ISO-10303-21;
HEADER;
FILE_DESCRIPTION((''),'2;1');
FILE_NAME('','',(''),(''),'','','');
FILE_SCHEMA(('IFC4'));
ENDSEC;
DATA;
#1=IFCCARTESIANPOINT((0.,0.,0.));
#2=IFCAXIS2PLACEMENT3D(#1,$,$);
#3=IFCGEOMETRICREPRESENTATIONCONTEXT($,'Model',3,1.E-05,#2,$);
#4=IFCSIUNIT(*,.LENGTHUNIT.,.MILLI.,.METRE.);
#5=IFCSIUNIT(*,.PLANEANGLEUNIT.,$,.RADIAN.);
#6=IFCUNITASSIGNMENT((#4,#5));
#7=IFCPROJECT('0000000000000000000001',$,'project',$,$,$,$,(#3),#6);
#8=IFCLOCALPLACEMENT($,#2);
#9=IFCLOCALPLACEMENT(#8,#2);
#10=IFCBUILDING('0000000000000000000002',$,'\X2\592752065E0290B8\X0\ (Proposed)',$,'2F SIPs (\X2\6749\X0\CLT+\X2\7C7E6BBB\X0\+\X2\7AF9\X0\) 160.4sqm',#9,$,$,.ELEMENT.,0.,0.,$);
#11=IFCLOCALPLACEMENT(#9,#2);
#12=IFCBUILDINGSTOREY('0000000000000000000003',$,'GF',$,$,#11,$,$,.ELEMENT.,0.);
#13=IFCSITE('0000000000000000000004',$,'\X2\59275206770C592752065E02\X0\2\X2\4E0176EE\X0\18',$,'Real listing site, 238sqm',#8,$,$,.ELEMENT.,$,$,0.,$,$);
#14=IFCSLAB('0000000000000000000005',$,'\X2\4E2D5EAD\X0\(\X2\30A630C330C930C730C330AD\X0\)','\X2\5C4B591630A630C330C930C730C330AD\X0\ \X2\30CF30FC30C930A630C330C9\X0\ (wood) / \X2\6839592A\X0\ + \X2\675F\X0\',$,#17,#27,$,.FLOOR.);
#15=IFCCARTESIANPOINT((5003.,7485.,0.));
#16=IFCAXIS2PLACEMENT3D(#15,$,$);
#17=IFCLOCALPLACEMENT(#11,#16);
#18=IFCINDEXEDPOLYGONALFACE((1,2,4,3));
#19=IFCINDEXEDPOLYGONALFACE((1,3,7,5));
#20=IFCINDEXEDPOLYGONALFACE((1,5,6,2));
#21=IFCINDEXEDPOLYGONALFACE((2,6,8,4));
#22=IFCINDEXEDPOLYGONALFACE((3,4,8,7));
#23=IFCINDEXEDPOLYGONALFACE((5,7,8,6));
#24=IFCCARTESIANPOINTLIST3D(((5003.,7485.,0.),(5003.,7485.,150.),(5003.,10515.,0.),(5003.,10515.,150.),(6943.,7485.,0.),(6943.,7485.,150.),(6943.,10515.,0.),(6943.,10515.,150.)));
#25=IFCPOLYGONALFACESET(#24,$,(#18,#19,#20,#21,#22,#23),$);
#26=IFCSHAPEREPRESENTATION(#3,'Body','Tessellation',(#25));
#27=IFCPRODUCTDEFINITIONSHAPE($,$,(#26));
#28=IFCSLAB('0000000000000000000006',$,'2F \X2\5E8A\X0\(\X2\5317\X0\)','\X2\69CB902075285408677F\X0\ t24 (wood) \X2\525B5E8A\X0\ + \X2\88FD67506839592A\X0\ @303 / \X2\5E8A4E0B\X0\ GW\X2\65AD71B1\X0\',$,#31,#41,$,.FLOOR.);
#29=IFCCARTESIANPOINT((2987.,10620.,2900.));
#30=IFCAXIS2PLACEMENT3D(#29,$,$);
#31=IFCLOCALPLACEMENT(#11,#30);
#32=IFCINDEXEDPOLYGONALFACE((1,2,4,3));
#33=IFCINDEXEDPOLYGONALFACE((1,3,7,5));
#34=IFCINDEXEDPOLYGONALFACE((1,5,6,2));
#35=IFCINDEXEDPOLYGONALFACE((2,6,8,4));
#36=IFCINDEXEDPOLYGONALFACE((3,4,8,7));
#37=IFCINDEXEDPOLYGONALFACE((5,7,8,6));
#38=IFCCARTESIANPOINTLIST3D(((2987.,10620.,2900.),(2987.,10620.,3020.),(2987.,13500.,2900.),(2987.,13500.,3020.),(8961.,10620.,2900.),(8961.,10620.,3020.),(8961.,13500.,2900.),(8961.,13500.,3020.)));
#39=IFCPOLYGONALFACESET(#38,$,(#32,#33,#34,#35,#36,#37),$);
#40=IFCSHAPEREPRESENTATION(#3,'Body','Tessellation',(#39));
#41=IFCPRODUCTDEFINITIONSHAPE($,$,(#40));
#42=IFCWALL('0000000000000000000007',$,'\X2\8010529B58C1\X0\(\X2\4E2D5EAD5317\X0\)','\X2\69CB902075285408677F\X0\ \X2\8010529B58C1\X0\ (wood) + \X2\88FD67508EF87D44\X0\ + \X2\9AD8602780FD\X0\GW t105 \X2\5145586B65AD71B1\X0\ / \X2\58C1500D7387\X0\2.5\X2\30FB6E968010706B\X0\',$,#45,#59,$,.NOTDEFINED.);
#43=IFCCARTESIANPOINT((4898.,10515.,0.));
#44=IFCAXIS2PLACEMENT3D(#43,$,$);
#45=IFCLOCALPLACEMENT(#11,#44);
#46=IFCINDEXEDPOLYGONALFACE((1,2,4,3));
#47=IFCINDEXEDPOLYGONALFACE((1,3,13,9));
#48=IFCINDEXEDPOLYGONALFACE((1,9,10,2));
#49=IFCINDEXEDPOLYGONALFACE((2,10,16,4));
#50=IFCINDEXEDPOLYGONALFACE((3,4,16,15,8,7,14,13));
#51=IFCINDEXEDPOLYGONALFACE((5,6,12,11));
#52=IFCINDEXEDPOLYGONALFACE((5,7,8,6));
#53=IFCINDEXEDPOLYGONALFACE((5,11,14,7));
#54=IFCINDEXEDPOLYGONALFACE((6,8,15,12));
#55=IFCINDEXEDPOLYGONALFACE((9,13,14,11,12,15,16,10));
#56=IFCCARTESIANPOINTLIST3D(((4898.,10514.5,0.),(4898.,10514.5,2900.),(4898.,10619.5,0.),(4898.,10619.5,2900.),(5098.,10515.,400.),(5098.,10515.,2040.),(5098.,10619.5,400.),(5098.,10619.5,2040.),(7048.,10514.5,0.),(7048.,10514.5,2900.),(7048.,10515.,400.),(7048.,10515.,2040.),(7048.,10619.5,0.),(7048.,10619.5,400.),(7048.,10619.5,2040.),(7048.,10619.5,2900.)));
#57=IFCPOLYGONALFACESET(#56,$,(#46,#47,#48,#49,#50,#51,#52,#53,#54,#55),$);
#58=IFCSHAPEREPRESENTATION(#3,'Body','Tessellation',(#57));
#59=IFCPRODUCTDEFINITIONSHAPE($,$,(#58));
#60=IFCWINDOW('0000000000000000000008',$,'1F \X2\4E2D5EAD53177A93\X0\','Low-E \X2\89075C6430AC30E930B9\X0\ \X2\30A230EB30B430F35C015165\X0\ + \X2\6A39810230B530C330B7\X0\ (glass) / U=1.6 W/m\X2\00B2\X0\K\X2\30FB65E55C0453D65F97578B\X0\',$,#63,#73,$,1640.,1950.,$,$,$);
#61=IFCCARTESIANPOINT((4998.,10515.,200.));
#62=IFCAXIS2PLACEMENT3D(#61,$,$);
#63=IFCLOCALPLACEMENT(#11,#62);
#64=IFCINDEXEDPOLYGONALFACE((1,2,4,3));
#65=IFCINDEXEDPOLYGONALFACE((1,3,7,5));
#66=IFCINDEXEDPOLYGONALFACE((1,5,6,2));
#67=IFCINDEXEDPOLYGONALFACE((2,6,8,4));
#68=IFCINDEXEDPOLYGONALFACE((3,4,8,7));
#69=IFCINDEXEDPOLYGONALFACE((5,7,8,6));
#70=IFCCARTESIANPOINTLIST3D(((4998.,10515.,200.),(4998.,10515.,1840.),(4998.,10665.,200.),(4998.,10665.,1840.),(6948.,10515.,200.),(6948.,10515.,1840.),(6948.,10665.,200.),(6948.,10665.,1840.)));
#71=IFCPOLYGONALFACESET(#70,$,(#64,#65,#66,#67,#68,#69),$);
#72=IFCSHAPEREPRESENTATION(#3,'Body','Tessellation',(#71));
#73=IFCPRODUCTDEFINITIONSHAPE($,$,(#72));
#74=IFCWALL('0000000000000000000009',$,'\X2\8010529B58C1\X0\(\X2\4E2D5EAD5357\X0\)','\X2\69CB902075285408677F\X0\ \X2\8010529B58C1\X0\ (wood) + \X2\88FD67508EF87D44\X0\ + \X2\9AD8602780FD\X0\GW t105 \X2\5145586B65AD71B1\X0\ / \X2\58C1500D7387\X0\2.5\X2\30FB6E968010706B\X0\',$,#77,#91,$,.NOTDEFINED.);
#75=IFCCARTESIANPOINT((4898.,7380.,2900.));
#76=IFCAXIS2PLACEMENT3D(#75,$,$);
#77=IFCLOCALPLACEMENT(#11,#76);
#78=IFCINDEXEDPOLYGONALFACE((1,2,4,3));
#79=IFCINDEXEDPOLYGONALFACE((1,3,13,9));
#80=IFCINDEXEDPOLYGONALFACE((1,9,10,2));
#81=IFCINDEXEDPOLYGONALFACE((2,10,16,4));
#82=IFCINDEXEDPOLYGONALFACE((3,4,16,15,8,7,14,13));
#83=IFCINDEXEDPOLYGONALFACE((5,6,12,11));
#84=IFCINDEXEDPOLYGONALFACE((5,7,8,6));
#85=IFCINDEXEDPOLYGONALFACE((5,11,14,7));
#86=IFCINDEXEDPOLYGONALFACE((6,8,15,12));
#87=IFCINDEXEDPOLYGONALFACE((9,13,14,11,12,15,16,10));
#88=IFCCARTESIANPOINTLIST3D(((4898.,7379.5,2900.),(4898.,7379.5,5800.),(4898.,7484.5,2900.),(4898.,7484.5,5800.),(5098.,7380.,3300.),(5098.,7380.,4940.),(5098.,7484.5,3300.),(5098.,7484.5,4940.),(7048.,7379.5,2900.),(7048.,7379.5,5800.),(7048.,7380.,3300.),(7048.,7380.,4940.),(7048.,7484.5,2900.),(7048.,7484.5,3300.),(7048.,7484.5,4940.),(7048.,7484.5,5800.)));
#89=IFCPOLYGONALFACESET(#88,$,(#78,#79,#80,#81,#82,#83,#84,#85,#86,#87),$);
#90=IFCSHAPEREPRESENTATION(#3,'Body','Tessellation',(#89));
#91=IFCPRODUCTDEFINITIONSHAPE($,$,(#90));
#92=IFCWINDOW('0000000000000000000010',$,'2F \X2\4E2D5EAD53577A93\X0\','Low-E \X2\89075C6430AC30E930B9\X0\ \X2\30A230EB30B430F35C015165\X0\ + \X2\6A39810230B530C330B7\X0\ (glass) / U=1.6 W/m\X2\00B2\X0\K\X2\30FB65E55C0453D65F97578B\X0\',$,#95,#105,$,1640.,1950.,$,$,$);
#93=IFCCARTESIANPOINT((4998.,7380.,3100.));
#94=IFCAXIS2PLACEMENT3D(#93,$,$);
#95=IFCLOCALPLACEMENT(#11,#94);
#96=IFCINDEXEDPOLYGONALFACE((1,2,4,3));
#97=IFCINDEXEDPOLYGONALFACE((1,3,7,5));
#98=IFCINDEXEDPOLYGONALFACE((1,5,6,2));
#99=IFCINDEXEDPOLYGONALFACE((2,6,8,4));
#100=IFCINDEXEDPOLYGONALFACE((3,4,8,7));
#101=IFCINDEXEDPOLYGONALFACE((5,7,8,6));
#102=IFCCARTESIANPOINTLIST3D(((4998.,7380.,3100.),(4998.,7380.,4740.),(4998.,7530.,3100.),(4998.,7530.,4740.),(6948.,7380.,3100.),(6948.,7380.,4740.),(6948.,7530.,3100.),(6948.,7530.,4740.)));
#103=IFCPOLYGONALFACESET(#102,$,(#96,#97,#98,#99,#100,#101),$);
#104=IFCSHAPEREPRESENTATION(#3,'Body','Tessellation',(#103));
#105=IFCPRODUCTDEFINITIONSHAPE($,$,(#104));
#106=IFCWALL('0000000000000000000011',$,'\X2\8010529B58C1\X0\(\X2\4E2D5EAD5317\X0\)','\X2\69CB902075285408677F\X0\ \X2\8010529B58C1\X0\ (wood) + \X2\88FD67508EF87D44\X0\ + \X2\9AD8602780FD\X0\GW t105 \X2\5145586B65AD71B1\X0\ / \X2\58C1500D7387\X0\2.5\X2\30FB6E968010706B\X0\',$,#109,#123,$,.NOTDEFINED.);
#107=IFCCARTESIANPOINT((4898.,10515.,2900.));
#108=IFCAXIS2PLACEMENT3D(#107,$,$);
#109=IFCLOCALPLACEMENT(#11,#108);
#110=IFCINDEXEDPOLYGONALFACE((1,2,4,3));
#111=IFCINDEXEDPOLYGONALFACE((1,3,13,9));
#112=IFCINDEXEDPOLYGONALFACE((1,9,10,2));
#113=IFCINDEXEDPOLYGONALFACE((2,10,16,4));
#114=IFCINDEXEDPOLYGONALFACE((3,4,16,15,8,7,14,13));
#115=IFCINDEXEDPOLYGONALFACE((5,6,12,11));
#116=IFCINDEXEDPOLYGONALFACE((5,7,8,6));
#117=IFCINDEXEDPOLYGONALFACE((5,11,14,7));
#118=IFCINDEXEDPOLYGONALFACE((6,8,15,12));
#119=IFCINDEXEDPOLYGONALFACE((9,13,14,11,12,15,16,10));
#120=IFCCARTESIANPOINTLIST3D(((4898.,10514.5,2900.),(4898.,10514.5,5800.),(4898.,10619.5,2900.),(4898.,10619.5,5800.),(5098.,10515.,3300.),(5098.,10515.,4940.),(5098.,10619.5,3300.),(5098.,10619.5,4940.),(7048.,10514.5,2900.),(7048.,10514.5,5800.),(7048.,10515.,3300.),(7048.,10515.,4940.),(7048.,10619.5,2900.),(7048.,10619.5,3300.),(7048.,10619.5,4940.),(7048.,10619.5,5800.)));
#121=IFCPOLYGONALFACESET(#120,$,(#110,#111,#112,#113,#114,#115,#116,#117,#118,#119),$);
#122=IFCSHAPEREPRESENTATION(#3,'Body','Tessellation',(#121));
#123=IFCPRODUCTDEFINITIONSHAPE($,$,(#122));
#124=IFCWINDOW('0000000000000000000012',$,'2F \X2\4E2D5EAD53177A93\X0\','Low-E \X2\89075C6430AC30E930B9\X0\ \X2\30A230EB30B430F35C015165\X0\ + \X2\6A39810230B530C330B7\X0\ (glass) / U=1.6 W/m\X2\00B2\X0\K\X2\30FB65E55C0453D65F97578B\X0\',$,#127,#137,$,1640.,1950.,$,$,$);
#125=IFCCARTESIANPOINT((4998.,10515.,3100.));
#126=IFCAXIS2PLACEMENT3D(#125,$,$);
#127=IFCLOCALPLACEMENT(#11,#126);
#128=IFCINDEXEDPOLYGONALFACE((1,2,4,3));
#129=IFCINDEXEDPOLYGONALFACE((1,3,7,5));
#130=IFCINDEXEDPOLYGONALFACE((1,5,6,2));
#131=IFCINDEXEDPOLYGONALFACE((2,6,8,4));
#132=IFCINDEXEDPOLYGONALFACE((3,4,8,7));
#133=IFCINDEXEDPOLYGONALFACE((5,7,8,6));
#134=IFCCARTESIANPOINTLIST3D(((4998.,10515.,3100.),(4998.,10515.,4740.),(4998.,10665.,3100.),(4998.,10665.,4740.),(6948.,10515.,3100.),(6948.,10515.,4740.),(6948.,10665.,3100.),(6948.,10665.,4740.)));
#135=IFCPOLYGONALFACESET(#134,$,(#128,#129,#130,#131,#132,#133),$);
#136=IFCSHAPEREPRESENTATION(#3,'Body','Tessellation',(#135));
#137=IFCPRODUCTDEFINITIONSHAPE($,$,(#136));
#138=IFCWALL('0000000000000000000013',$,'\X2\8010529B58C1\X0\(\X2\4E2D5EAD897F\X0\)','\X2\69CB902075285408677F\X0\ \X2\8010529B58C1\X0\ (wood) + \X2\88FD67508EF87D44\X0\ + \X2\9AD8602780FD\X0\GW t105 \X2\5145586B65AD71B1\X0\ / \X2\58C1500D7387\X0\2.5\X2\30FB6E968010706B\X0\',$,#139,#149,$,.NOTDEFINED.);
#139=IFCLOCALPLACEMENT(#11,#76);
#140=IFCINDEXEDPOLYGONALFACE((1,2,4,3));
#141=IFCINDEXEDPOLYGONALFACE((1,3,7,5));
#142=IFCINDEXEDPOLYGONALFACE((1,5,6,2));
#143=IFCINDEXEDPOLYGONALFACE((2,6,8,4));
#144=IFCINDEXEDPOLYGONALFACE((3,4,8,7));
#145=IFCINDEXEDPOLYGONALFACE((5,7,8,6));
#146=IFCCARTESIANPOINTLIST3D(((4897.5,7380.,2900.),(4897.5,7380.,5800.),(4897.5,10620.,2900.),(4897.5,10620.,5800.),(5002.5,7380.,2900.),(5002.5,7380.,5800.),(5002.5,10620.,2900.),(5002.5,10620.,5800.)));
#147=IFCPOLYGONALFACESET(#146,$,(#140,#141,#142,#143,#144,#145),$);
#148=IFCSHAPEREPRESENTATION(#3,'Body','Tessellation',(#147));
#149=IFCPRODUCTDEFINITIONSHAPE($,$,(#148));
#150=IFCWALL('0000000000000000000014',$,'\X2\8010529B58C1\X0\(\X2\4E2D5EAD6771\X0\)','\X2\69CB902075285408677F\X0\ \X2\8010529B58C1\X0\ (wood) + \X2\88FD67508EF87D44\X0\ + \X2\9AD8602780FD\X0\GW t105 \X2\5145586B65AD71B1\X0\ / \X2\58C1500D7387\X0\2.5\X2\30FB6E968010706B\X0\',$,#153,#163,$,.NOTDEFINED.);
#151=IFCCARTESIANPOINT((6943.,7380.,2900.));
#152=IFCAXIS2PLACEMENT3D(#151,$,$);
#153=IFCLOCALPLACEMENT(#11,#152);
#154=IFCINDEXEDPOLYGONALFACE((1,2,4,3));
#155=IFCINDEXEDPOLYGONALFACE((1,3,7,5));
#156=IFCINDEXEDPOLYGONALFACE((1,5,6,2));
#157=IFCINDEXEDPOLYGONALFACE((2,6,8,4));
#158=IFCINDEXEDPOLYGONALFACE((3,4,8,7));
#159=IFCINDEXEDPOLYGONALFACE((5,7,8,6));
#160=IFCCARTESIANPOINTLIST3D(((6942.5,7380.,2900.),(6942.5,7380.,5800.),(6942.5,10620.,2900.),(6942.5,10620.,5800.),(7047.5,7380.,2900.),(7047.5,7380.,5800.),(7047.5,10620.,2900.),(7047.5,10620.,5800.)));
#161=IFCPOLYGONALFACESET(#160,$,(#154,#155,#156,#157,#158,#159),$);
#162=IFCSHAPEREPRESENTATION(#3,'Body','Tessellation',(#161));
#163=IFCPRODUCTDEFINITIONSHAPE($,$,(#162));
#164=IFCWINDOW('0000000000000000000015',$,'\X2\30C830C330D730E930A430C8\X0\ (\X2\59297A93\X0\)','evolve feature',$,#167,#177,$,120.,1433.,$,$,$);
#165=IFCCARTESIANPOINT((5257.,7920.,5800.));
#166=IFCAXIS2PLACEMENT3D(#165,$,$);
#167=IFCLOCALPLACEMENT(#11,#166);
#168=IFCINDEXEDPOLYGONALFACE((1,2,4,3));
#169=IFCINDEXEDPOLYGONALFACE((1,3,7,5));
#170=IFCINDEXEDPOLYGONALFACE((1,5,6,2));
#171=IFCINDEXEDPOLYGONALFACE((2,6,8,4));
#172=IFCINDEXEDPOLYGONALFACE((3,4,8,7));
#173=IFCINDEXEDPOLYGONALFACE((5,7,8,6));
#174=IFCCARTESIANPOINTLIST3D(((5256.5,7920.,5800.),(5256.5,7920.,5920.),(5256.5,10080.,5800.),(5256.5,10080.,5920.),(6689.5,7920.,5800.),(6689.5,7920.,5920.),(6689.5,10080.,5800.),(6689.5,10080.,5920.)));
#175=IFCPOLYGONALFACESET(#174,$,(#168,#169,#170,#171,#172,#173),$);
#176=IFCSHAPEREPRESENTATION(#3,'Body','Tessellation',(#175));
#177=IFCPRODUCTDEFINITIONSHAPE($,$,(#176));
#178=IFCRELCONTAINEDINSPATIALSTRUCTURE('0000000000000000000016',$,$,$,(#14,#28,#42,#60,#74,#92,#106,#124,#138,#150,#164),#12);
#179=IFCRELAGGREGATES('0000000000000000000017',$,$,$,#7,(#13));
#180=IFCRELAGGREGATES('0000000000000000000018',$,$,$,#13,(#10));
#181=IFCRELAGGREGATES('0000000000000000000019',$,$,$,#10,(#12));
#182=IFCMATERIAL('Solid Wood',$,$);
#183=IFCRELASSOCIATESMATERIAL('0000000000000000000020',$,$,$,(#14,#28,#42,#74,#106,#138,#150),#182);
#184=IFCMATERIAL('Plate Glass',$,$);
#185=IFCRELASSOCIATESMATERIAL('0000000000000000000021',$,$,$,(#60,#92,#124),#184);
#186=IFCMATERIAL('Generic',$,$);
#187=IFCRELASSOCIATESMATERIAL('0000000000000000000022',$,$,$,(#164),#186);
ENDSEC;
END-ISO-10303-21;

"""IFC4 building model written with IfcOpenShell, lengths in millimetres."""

from ifc_helpers import new_model, si_unit, frame, frame_2d, origin, place, context, project, spatial, rectangle, extrude, material, element, fill, save


model = new_model("IFC4")

# Units and contexts
model_context = context("Model", 3, precision=1e-05, world=origin())
ifc_project = project(units=[si_unit("LENGTHUNIT", "METRE", prefix="MILLI"), si_unit("PLANEANGLEUNIT", "RADIAN")], contexts=[model_context])

# Site, building, storey
site_placement = place(None, origin())
site = spatial("IfcSite", under=ifc_project, at=site_placement, Name="大分県大分市2丁目18", ObjectType="Real listing site, 238sqm", CompositionType="ELEMENT", RefElevation=0.0)
building_placement = place(site_placement, origin())
building = spatial("IfcBuilding", under=site, at=building_placement, Name="大分市邸 (Proposed)", ObjectType="2F SIPs (杉CLT+籾殻+竹) 160.4sqm", CompositionType="ELEMENT", ElevationOfRefHeight=0.0, ElevationOfTerrain=0.0)
storey_placement = place(building_placement, origin())
storey = spatial("IfcBuildingStorey", under=building, at=storey_placement, Name="GF", CompositionType="ELEMENT", Elevation=0.0)

# Slabs
ifc_material_1 = material(Name="Solid Wood")
slab_1_placement = place(storey_placement, frame((5003.0, 7485.0, 0.0)))
element("IfcSlab", 1, at=slab_1_placement, inside=storey, material=ifc_material_1, Name="中庭(ウッドデッキ)", Description="屋外ウッドデッキ ハードウッド (wood) / 根太 + 束", PredefinedType="FLOOR", context=model_context, shape_type="SweptSolid", body=[
    extrude(rectangle(XDim=1940.0, YDim=3030.0, at=frame_2d((970.0, 1515.0))), frame((5003.0, 7485.0, 0.0)), (0.0, 0.0, 1.0), 150.0),
])
slab_2_placement = place(storey_placement, frame((2987.0, 10620.0, 2900.0)))
element("IfcSlab", 2, at=slab_2_placement, inside=storey, material=ifc_material_1, Name="2F 床(北)", Description="構造用合板 t24 (wood) 剛床 + 製材根太 @303 / 床下 GW断熱", PredefinedType="FLOOR", context=model_context, shape_type="SweptSolid", body=[
    extrude(rectangle(XDim=5974.0, YDim=2880.0, at=frame_2d((2987.0, 1440.0))), frame((2987.0, 10620.0, 2900.0)), (0.0, 0.0, 1.0), 120.0),
])
ifc_material_2 = material(Name="Generic")

# Wall, opening, window
wall_1_placement = place(storey_placement, frame((4898.0, 10515.0, 0.0)))
wall_1 = element("IfcWall", 3, at=wall_1_placement, inside=storey, material=ifc_material_1, Name="耐力壁(中庭北)", Description="構造用合板 耐力壁 (wood) + 製材軸組 + 高性能GW t105 充填断熱 / 壁倍率2.5・準耐火", PredefinedType="NOTDEFINED", context=model_context, shape_type="SweptSolid", body=[
    extrude(rectangle(XDim=2150.0, YDim=105.0, at=frame_2d((1075.0, 52.0))), frame((4898.0, 10515.0, 0.0)), (0.0, 0.0, 1.0), 2900.0),
])
opening_1_placement = place(storey_placement, frame((4998.0, 10515.0, 200.0)))
opening_1 = element("IfcOpeningElement", 4, at=opening_1_placement, cuts=wall_1, PredefinedType="NOTDEFINED", context=model_context, shape_type="SweptSolid", body=[
    extrude(rectangle(XDim=1950.0, YDim=150.0, at=frame_2d((975.0, 75.0))), frame((4998.0, 10515.0, 200.0)), (0.0, 0.0, 1.0), 1640.0),
])
ifc_material_3 = material(Name="Plate Glass")
window_1_placement = place(storey_placement, frame((4998.0, 10515.0, 200.0)))
window_1 = element("IfcWindow", 5, at=window_1_placement, inside=storey, material=ifc_material_3, Name="1F 中庭北窓", Description="Low-E 複層ガラス アルゴン封入 + 樹脂サッシ (glass) / U=1.6 W/m²K・日射取得型", OverallHeight=1640.0, OverallWidth=1950.0, context=model_context, shape_type="SweptSolid", body=[
    extrude(rectangle(XDim=1950.0, YDim=150.0, at=frame_2d((975.0, 75.0))), frame((4998.0, 10515.0, 200.0)), (0.0, 0.0, 1.0), 1640.0),
])
fill(opening_1, window_1)

# Walls, openings, windows
wall_2_placement = place(storey_placement, frame((4898.0, 7380.0, 2900.0)))
wall_2 = element("IfcWall", 6, at=wall_2_placement, inside=storey, material=ifc_material_1, Name="耐力壁(中庭南)", Description="構造用合板 耐力壁 (wood) + 製材軸組 + 高性能GW t105 充填断熱 / 壁倍率2.5・準耐火", PredefinedType="NOTDEFINED", context=model_context, shape_type="SweptSolid", body=[
    extrude(rectangle(XDim=2150.0, YDim=105.0, at=frame_2d((1075.0, 52.0))), frame((4898.0, 7380.0, 2900.0)), (0.0, 0.0, 1.0), 2900.0),
])
opening_2_placement = place(storey_placement, frame((4998.0, 7380.0, 3100.0)))
opening_2 = element("IfcOpeningElement", 7, at=opening_2_placement, cuts=wall_2, PredefinedType="NOTDEFINED", context=model_context, shape_type="SweptSolid", body=[
    extrude(rectangle(XDim=1950.0, YDim=150.0, at=frame_2d((975.0, 75.0))), frame((4998.0, 7380.0, 3100.0)), (0.0, 0.0, 1.0), 1640.0),
])
window_2_placement = place(storey_placement, frame((4998.0, 7380.0, 3100.0)))
window_2 = element("IfcWindow", 8, at=window_2_placement, inside=storey, material=ifc_material_3, Name="2F 中庭南窓", Description="Low-E 複層ガラス アルゴン封入 + 樹脂サッシ (glass) / U=1.6 W/m²K・日射取得型", OverallHeight=1640.0, OverallWidth=1950.0, context=model_context, shape_type="SweptSolid", body=[
    extrude(rectangle(XDim=1950.0, YDim=150.0, at=frame_2d((975.0, 75.0))), frame((4998.0, 7380.0, 3100.0)), (0.0, 0.0, 1.0), 1640.0),
])
fill(opening_2, window_2)
wall_3_placement = place(storey_placement, frame((4898.0, 10515.0, 2900.0)))
wall_3 = element("IfcWall", 9, at=wall_3_placement, inside=storey, material=ifc_material_1, Name="耐力壁(中庭北)", Description="構造用合板 耐力壁 (wood) + 製材軸組 + 高性能GW t105 充填断熱 / 壁倍率2.5・準耐火", PredefinedType="NOTDEFINED", context=model_context, shape_type="SweptSolid", body=[
    extrude(rectangle(XDim=2150.0, YDim=105.0, at=frame_2d((1075.0, 52.0))), frame((4898.0, 10515.0, 2900.0)), (0.0, 0.0, 1.0), 2900.0),
])
opening_3_placement = place(storey_placement, frame((4998.0, 10515.0, 3100.0)))
opening_3 = element("IfcOpeningElement", 10, at=opening_3_placement, cuts=wall_3, PredefinedType="NOTDEFINED", context=model_context, shape_type="SweptSolid", body=[
    extrude(rectangle(XDim=1950.0, YDim=150.0, at=frame_2d((975.0, 75.0))), frame((4998.0, 10515.0, 3100.0)), (0.0, 0.0, 1.0), 1640.0),
])
window_3_placement = place(storey_placement, frame((4998.0, 10515.0, 3100.0)))
window_3 = element("IfcWindow", 11, at=window_3_placement, inside=storey, material=ifc_material_3, Name="2F 中庭北窓", Description="Low-E 複層ガラス アルゴン封入 + 樹脂サッシ (glass) / U=1.6 W/m²K・日射取得型", OverallHeight=1640.0, OverallWidth=1950.0, context=model_context, shape_type="SweptSolid", body=[
    extrude(rectangle(XDim=1950.0, YDim=150.0, at=frame_2d((975.0, 75.0))), frame((4998.0, 10515.0, 3100.0)), (0.0, 0.0, 1.0), 1640.0),
])
fill(opening_3, window_3)

# Walls
wall_4_placement = place(storey_placement, frame((4898.0, 7380.0, 2900.0)))
element("IfcWall", 12, at=wall_4_placement, inside=storey, material=ifc_material_1, Name="耐力壁(中庭西)", Description="構造用合板 耐力壁 (wood) + 製材軸組 + 高性能GW t105 充填断熱 / 壁倍率2.5・準耐火", PredefinedType="NOTDEFINED", context=model_context, shape_type="SweptSolid", body=[
    extrude(rectangle(XDim=105.0, YDim=3240.0, at=frame_2d((52.0, 1620.0))), frame((4898.0, 7380.0, 2900.0)), (0.0, 0.0, 1.0), 2900.0),
])
wall_5_placement = place(storey_placement, frame((6943.0, 7380.0, 2900.0)))
element("IfcWall", 13, at=wall_5_placement, inside=storey, material=ifc_material_1, Name="耐力壁(中庭東)", Description="構造用合板 耐力壁 (wood) + 製材軸組 + 高性能GW t105 充填断熱 / 壁倍率2.5・準耐火", PredefinedType="NOTDEFINED", context=model_context, shape_type="SweptSolid", body=[
    extrude(rectangle(XDim=105.0, YDim=3240.0, at=frame_2d((52.0, 1620.0))), frame((6943.0, 7380.0, 2900.0)), (0.0, 0.0, 1.0), 2900.0),
])

# Window
window_4_placement = place(storey_placement, frame((5257.0, 7920.0, 5800.0)))
element("IfcWindow", 14, at=window_4_placement, inside=storey, material=ifc_material_2, Name="トップライト (天窓)", Description="evolve feature", OverallHeight=120.0, OverallWidth=1433.0, context=model_context, shape_type="SweptSolid", body=[
    extrude(rectangle(XDim=1433.0, YDim=2160.0, at=frame_2d((716.0, 1080.0))), frame((5257.0, 7920.0, 5800.0)), (0.0, 0.0, 1.0), 120.0),
])

save(model, "model.ifc")
